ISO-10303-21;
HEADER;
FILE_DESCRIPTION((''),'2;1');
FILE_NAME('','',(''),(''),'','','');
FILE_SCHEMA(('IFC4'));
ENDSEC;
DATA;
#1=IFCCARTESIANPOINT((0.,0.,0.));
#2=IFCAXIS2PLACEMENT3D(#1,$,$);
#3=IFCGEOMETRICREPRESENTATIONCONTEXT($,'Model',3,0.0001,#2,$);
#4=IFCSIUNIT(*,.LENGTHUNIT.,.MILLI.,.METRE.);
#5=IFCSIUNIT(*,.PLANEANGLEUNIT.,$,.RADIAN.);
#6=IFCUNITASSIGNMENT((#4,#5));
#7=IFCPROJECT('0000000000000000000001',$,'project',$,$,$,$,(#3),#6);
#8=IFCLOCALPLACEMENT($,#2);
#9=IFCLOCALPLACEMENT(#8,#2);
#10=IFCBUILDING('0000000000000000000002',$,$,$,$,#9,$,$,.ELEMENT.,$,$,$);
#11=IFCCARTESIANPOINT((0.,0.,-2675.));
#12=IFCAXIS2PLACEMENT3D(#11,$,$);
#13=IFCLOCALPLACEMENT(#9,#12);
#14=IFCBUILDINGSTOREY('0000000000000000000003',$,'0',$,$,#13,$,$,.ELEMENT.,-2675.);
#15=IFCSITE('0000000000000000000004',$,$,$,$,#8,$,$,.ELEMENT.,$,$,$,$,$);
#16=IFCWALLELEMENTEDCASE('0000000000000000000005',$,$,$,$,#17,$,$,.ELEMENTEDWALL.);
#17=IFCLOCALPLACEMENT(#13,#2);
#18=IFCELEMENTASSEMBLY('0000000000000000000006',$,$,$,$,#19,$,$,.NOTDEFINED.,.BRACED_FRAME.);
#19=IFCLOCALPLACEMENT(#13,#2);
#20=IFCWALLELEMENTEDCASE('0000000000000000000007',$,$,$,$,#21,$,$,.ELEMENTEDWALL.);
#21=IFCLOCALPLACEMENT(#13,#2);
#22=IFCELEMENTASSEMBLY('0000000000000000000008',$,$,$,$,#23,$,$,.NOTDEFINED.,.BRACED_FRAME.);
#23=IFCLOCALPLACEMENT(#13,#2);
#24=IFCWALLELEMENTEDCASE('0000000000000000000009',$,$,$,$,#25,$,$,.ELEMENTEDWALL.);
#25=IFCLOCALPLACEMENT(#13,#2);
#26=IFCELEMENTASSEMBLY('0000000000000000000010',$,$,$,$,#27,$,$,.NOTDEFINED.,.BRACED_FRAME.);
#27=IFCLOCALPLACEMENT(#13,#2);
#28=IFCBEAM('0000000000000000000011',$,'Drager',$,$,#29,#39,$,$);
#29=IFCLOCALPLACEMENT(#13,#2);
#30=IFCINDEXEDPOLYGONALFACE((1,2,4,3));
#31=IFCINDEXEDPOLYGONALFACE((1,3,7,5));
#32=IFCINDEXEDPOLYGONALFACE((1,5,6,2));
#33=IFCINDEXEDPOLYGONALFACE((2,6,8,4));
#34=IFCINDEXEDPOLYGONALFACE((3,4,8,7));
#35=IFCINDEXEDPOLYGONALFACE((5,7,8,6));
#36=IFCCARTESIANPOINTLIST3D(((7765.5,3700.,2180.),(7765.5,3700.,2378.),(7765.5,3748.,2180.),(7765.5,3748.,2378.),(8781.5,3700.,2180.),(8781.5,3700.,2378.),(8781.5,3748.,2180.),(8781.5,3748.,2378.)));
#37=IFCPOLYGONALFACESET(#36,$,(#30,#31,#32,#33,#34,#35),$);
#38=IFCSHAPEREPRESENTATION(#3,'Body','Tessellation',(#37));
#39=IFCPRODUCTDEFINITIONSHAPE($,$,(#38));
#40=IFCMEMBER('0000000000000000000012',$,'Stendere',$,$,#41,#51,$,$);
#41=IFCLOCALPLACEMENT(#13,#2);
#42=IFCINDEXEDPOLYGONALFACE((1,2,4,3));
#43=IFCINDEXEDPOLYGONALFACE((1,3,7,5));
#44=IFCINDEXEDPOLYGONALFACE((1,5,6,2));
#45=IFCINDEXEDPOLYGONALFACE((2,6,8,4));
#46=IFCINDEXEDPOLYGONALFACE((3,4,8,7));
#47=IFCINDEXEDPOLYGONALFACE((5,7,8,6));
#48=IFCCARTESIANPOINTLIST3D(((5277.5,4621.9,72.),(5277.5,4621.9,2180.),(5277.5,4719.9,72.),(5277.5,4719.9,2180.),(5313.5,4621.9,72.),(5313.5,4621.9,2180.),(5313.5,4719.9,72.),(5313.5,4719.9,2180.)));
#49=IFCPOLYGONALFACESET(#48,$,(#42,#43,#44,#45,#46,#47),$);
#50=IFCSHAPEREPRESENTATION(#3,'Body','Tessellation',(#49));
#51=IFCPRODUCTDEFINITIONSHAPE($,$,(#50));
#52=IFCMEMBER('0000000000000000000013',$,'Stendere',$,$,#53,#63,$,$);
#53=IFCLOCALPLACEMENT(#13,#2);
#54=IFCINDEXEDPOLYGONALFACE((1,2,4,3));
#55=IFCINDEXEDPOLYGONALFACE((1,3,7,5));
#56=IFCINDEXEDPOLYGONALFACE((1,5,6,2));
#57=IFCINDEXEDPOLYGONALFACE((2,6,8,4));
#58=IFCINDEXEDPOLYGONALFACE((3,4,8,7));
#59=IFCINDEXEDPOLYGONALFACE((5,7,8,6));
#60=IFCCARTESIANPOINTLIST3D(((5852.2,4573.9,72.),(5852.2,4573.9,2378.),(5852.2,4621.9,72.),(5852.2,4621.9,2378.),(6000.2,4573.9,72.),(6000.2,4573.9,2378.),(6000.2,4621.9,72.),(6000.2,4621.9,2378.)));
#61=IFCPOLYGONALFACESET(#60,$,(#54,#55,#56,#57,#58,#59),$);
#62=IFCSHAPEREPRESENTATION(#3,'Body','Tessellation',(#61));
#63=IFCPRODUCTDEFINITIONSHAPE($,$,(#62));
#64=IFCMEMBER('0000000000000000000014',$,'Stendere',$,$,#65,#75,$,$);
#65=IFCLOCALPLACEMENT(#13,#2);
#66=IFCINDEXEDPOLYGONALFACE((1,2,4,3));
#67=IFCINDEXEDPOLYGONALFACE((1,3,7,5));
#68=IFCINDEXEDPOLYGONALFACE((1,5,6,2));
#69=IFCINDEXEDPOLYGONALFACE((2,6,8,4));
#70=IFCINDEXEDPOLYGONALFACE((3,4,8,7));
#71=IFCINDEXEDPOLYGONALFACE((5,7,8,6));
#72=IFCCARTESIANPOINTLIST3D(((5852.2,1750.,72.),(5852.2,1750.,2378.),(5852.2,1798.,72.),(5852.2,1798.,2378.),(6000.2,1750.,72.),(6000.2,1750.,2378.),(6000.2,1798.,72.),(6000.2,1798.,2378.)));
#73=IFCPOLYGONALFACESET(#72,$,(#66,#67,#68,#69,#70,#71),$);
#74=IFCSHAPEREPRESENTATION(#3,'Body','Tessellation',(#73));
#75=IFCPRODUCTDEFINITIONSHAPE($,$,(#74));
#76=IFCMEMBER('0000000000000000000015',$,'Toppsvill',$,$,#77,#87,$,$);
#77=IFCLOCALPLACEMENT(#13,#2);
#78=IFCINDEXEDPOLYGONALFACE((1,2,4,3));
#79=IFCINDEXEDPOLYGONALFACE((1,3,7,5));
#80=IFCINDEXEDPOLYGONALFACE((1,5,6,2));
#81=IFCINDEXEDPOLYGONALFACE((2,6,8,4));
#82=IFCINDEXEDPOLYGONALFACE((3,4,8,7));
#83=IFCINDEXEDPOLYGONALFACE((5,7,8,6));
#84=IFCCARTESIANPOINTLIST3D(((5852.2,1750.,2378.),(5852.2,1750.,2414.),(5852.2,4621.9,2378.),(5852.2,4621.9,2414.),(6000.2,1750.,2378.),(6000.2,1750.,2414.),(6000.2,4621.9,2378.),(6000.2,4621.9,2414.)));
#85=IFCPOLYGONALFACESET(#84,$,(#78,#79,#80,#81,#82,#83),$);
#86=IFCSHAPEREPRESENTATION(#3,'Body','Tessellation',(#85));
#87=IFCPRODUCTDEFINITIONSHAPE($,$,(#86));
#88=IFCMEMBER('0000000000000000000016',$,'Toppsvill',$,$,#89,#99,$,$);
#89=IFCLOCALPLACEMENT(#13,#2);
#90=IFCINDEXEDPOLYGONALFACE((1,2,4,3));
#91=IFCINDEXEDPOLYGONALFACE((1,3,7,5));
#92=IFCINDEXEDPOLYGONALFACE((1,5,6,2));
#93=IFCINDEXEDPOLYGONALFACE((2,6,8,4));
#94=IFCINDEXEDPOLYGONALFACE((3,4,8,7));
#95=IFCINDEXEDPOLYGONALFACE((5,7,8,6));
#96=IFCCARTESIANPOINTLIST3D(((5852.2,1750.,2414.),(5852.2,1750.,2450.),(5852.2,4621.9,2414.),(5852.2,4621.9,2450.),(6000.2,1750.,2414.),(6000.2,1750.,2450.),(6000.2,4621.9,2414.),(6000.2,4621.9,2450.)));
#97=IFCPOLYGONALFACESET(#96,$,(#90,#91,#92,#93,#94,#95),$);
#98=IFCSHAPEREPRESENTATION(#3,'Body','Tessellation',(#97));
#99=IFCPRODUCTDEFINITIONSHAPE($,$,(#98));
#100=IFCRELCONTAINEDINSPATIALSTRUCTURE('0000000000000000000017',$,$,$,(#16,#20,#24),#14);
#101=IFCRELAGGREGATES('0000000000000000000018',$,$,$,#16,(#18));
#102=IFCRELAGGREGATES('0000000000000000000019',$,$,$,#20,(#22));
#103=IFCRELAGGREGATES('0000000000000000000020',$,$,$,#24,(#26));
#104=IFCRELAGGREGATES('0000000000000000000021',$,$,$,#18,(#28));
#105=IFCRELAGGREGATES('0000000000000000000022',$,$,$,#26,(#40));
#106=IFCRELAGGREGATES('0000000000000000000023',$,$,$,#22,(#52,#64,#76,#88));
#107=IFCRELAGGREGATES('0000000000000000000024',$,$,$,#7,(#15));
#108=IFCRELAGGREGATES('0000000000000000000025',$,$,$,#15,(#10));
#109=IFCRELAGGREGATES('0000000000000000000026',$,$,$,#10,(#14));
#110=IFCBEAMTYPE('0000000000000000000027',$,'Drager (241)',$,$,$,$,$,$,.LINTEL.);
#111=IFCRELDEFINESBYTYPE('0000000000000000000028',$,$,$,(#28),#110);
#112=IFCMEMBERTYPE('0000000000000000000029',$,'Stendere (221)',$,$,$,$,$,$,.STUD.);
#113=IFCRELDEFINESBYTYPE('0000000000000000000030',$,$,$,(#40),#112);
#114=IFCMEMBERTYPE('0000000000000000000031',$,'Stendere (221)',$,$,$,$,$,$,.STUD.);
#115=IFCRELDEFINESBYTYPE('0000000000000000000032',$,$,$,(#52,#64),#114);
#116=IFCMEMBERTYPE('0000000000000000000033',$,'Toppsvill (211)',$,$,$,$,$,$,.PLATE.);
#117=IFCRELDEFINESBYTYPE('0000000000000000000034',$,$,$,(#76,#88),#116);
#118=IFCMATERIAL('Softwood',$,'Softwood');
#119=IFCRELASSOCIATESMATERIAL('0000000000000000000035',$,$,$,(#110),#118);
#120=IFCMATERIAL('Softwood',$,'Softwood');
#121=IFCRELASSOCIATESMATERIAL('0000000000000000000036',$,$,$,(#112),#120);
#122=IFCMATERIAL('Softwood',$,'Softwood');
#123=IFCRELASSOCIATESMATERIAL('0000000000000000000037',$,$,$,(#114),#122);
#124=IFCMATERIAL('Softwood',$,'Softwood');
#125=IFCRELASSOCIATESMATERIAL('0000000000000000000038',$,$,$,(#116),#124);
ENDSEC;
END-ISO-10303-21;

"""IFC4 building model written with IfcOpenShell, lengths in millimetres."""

from ifc_helpers import new_model, si_unit, frame, origin, place, context, project, spatial, rectangle, extrude, material, material_profile, profile_set, type_object, element, aggregate, save


model = new_model("IFC4")

# Units and contexts
model_context = context("Model", 3, precision=0.0001, world=origin())
ifc_project = project(units=[si_unit("LENGTHUNIT", "METRE", prefix="MILLI"), si_unit("PLANEANGLEUNIT", "RADIAN")], contexts=[model_context])

# Site, building, storey
site_placement = place(None, origin())
site = spatial("IfcSite", under=ifc_project, at=site_placement, CompositionType="ELEMENT")
building_placement = place(site_placement, origin())
building = spatial("IfcBuilding", under=site, at=building_placement, CompositionType="ELEMENT")
storey_placement = place(building_placement, frame((0.0, 0.0, -2675.0)))
storey = spatial("IfcBuildingStorey", under=building, at=storey_placement, Name="0", CompositionType="ELEMENT", Elevation=-2675.0)

# Wall, element assembly
wall_1_placement = place(storey_placement, frame((6000.2, 3748.0, 0.0), z_axis=(0.0, -1.0, 0.0)))
wall_1 = element("IfcWallElementedCase", 1, at=wall_1_placement, inside=storey, PredefinedType="ELEMENTEDWALL")
assembly_1_placement = place(wall_1_placement, origin())
assembly_1 = element("IfcElementAssembly", 2, at=assembly_1_placement, AssemblyPlace="NOTDEFINED", PredefinedType="BRACED_FRAME")
aggregate(wall_1, [assembly_1])

# Wall, element assembly
wall_2_placement = place(storey_placement, frame((5852.2, 1750.0, 0.0), z_axis=(1.0, 0.0, 0.0), x_axis=(0.0, 1.0, 0.0)))
wall_2 = element("IfcWallElementedCase", 3, at=wall_2_placement, inside=storey, PredefinedType="ELEMENTEDWALL")
assembly_2_placement = place(wall_2_placement, origin())
assembly_2 = element("IfcElementAssembly", 4, at=assembly_2_placement, AssemblyPlace="NOTDEFINED", PredefinedType="BRACED_FRAME")
aggregate(wall_2, [assembly_2])

# Wall, element assembly
wall_3_placement = place(storey_placement, frame((352.0, 4719.9, 0.0), z_axis=(0.0, -1.0, 0.0)))
wall_3 = element("IfcWallElementedCase", 5, at=wall_3_placement, inside=storey, PredefinedType="ELEMENTEDWALL")
assembly_3_placement = place(wall_3_placement, origin())
assembly_3 = element("IfcElementAssembly", 6, at=assembly_3_placement, AssemblyPlace="NOTDEFINED", PredefinedType="BRACED_FRAME")
aggregate(wall_3, [assembly_3])

# Beam
ifc_material_1 = material(Name="Softwood", Category="Softwood")
ifc_material_profile_1 = material_profile(ifc_material_1, rectangle(XDim=198.0, YDim=48.0), Name="Drager (241)")
ifc_profile_set_1 = profile_set([ifc_material_profile_1])
beam_type = type_object("IfcBeamType", Name="Drager (241)", PredefinedType="LINTEL", material=ifc_profile_set_1)
beam_1_placement = place(assembly_1_placement, frame((1765.4, 2279.0, 0.0), z_axis=(1.0, 0.0, 0.0), x_axis=(0.0, 1.0, 0.0)))
beam_1 = element("IfcBeam", 7, at=beam_1_placement, type_object=beam_type, Name="Drager", context=model_context, shape_type="SweptSolid", body=[
    extrude(rectangle(XDim=198.0, YDim=48.0), frame((0.0, 24.0, 0.0)), (0.0, 0.0, 1.0), 1016.0),
])
aggregate(assembly_1, [beam_1])

# Members
ifc_material_2 = material(Name="Softwood", Category="Softwood")
ifc_material_profile_2 = material_profile(ifc_material_2, rectangle(XDim=36.0, YDim=98.0), Name="Stendere (221)")
ifc_profile_set_2 = profile_set([ifc_material_profile_2])
member_type_1 = type_object("IfcMemberType", Name="Stendere (221)", PredefinedType="STUD", material=ifc_profile_set_2)
member_1_placement = place(assembly_3_placement, frame((4943.5, 72.0, 0.0), z_axis=(0.0, 1.0, 0.0), x_axis=(-1.0, 0.0, 0.0)))
member_1 = element("IfcMember", 8, at=member_1_placement, type_object=member_type_1, Name="Stendere", context=model_context, shape_type="SweptSolid", body=[
    extrude(rectangle(XDim=36.0, YDim=98.0), frame((0.0, 49.0, 0.0)), (0.0, 0.0, 1.0), 2108.0),
])
aggregate(assembly_3, [member_1])
ifc_material_3 = material(Name="Softwood", Category="Softwood")
ifc_material_profile_3 = material_profile(ifc_material_3, rectangle(XDim=48.0, YDim=148.0), Name="Stendere (221)")
ifc_profile_set_3 = profile_set([ifc_material_profile_3])
member_type_2 = type_object("IfcMemberType", Name="Stendere (221)", PredefinedType="STUD", material=ifc_profile_set_3)
member_2_placement = place(assembly_2_placement, frame((2847.9, 72.0, 0.0), z_axis=(0.0, 1.0, 0.0), x_axis=(-1.0, 0.0, 0.0)))
member_2 = element("IfcMember", 9, at=member_2_placement, type_object=member_type_2, Name="Stendere", context=model_context, shape_type="SweptSolid", body=[
    extrude(rectangle(XDim=48.0, YDim=148.0), frame((0.0, 74.0, 0.0)), (0.0, 0.0, 1.0), 2306.0),
])
member_3_placement = place(assembly_2_placement, frame((24.0, 72.0, 0.0), z_axis=(0.0, 1.0, 0.0), x_axis=(-1.0, 0.0, 0.0)))
member_3 = element("IfcMember", 10, at=member_3_placement, type_object=member_type_2, Name="Stendere", context=model_context, shape_type="SweptSolid", body=[
    extrude(rectangle(XDim=48.0, YDim=148.0), frame((0.0, 74.0, 0.0)), (0.0, 0.0, 1.0), 2306.0),
])
ifc_material_4 = material(Name="Softwood", Category="Softwood")
ifc_material_profile_4 = material_profile(ifc_material_4, rectangle(XDim=36.0, YDim=148.0), Name="Toppsvill (211)")
ifc_profile_set_4 = profile_set([ifc_material_profile_4])
member_type_3 = type_object("IfcMemberType", Name="Toppsvill (211)", PredefinedType="PLATE", material=ifc_profile_set_4)
member_4_placement = place(assembly_2_placement, frame((0.0, 2396.0, 0.0), z_axis=(1.0, 0.0, 0.0), x_axis=(0.0, 1.0, 0.0)))
member_4 = element("IfcMember", 11, at=member_4_placement, type_object=member_type_3, Name="Toppsvill", context=model_context, shape_type="SweptSolid", body=[
    extrude(rectangle(XDim=36.0, YDim=148.0), frame((0.0, 74.0, 0.0)), (0.0, 0.0, 1.0), 2871.9),
])
member_5_placement = place(assembly_2_placement, frame((0.0, 2432.0, 0.0), z_axis=(1.0, 0.0, 0.0), x_axis=(0.0, 1.0, 0.0)))
member_5 = element("IfcMember", 12, at=member_5_placement, type_object=member_type_3, Name="Toppsvill", context=model_context, shape_type="SweptSolid", body=[
    extrude(rectangle(XDim=36.0, YDim=148.0), frame((0.0, 74.0, 0.0)), (0.0, 0.0, 1.0), 2871.9),
])
aggregate(assembly_2, [member_2, member_3, member_4, member_5])

save(model, "model.ifc")
